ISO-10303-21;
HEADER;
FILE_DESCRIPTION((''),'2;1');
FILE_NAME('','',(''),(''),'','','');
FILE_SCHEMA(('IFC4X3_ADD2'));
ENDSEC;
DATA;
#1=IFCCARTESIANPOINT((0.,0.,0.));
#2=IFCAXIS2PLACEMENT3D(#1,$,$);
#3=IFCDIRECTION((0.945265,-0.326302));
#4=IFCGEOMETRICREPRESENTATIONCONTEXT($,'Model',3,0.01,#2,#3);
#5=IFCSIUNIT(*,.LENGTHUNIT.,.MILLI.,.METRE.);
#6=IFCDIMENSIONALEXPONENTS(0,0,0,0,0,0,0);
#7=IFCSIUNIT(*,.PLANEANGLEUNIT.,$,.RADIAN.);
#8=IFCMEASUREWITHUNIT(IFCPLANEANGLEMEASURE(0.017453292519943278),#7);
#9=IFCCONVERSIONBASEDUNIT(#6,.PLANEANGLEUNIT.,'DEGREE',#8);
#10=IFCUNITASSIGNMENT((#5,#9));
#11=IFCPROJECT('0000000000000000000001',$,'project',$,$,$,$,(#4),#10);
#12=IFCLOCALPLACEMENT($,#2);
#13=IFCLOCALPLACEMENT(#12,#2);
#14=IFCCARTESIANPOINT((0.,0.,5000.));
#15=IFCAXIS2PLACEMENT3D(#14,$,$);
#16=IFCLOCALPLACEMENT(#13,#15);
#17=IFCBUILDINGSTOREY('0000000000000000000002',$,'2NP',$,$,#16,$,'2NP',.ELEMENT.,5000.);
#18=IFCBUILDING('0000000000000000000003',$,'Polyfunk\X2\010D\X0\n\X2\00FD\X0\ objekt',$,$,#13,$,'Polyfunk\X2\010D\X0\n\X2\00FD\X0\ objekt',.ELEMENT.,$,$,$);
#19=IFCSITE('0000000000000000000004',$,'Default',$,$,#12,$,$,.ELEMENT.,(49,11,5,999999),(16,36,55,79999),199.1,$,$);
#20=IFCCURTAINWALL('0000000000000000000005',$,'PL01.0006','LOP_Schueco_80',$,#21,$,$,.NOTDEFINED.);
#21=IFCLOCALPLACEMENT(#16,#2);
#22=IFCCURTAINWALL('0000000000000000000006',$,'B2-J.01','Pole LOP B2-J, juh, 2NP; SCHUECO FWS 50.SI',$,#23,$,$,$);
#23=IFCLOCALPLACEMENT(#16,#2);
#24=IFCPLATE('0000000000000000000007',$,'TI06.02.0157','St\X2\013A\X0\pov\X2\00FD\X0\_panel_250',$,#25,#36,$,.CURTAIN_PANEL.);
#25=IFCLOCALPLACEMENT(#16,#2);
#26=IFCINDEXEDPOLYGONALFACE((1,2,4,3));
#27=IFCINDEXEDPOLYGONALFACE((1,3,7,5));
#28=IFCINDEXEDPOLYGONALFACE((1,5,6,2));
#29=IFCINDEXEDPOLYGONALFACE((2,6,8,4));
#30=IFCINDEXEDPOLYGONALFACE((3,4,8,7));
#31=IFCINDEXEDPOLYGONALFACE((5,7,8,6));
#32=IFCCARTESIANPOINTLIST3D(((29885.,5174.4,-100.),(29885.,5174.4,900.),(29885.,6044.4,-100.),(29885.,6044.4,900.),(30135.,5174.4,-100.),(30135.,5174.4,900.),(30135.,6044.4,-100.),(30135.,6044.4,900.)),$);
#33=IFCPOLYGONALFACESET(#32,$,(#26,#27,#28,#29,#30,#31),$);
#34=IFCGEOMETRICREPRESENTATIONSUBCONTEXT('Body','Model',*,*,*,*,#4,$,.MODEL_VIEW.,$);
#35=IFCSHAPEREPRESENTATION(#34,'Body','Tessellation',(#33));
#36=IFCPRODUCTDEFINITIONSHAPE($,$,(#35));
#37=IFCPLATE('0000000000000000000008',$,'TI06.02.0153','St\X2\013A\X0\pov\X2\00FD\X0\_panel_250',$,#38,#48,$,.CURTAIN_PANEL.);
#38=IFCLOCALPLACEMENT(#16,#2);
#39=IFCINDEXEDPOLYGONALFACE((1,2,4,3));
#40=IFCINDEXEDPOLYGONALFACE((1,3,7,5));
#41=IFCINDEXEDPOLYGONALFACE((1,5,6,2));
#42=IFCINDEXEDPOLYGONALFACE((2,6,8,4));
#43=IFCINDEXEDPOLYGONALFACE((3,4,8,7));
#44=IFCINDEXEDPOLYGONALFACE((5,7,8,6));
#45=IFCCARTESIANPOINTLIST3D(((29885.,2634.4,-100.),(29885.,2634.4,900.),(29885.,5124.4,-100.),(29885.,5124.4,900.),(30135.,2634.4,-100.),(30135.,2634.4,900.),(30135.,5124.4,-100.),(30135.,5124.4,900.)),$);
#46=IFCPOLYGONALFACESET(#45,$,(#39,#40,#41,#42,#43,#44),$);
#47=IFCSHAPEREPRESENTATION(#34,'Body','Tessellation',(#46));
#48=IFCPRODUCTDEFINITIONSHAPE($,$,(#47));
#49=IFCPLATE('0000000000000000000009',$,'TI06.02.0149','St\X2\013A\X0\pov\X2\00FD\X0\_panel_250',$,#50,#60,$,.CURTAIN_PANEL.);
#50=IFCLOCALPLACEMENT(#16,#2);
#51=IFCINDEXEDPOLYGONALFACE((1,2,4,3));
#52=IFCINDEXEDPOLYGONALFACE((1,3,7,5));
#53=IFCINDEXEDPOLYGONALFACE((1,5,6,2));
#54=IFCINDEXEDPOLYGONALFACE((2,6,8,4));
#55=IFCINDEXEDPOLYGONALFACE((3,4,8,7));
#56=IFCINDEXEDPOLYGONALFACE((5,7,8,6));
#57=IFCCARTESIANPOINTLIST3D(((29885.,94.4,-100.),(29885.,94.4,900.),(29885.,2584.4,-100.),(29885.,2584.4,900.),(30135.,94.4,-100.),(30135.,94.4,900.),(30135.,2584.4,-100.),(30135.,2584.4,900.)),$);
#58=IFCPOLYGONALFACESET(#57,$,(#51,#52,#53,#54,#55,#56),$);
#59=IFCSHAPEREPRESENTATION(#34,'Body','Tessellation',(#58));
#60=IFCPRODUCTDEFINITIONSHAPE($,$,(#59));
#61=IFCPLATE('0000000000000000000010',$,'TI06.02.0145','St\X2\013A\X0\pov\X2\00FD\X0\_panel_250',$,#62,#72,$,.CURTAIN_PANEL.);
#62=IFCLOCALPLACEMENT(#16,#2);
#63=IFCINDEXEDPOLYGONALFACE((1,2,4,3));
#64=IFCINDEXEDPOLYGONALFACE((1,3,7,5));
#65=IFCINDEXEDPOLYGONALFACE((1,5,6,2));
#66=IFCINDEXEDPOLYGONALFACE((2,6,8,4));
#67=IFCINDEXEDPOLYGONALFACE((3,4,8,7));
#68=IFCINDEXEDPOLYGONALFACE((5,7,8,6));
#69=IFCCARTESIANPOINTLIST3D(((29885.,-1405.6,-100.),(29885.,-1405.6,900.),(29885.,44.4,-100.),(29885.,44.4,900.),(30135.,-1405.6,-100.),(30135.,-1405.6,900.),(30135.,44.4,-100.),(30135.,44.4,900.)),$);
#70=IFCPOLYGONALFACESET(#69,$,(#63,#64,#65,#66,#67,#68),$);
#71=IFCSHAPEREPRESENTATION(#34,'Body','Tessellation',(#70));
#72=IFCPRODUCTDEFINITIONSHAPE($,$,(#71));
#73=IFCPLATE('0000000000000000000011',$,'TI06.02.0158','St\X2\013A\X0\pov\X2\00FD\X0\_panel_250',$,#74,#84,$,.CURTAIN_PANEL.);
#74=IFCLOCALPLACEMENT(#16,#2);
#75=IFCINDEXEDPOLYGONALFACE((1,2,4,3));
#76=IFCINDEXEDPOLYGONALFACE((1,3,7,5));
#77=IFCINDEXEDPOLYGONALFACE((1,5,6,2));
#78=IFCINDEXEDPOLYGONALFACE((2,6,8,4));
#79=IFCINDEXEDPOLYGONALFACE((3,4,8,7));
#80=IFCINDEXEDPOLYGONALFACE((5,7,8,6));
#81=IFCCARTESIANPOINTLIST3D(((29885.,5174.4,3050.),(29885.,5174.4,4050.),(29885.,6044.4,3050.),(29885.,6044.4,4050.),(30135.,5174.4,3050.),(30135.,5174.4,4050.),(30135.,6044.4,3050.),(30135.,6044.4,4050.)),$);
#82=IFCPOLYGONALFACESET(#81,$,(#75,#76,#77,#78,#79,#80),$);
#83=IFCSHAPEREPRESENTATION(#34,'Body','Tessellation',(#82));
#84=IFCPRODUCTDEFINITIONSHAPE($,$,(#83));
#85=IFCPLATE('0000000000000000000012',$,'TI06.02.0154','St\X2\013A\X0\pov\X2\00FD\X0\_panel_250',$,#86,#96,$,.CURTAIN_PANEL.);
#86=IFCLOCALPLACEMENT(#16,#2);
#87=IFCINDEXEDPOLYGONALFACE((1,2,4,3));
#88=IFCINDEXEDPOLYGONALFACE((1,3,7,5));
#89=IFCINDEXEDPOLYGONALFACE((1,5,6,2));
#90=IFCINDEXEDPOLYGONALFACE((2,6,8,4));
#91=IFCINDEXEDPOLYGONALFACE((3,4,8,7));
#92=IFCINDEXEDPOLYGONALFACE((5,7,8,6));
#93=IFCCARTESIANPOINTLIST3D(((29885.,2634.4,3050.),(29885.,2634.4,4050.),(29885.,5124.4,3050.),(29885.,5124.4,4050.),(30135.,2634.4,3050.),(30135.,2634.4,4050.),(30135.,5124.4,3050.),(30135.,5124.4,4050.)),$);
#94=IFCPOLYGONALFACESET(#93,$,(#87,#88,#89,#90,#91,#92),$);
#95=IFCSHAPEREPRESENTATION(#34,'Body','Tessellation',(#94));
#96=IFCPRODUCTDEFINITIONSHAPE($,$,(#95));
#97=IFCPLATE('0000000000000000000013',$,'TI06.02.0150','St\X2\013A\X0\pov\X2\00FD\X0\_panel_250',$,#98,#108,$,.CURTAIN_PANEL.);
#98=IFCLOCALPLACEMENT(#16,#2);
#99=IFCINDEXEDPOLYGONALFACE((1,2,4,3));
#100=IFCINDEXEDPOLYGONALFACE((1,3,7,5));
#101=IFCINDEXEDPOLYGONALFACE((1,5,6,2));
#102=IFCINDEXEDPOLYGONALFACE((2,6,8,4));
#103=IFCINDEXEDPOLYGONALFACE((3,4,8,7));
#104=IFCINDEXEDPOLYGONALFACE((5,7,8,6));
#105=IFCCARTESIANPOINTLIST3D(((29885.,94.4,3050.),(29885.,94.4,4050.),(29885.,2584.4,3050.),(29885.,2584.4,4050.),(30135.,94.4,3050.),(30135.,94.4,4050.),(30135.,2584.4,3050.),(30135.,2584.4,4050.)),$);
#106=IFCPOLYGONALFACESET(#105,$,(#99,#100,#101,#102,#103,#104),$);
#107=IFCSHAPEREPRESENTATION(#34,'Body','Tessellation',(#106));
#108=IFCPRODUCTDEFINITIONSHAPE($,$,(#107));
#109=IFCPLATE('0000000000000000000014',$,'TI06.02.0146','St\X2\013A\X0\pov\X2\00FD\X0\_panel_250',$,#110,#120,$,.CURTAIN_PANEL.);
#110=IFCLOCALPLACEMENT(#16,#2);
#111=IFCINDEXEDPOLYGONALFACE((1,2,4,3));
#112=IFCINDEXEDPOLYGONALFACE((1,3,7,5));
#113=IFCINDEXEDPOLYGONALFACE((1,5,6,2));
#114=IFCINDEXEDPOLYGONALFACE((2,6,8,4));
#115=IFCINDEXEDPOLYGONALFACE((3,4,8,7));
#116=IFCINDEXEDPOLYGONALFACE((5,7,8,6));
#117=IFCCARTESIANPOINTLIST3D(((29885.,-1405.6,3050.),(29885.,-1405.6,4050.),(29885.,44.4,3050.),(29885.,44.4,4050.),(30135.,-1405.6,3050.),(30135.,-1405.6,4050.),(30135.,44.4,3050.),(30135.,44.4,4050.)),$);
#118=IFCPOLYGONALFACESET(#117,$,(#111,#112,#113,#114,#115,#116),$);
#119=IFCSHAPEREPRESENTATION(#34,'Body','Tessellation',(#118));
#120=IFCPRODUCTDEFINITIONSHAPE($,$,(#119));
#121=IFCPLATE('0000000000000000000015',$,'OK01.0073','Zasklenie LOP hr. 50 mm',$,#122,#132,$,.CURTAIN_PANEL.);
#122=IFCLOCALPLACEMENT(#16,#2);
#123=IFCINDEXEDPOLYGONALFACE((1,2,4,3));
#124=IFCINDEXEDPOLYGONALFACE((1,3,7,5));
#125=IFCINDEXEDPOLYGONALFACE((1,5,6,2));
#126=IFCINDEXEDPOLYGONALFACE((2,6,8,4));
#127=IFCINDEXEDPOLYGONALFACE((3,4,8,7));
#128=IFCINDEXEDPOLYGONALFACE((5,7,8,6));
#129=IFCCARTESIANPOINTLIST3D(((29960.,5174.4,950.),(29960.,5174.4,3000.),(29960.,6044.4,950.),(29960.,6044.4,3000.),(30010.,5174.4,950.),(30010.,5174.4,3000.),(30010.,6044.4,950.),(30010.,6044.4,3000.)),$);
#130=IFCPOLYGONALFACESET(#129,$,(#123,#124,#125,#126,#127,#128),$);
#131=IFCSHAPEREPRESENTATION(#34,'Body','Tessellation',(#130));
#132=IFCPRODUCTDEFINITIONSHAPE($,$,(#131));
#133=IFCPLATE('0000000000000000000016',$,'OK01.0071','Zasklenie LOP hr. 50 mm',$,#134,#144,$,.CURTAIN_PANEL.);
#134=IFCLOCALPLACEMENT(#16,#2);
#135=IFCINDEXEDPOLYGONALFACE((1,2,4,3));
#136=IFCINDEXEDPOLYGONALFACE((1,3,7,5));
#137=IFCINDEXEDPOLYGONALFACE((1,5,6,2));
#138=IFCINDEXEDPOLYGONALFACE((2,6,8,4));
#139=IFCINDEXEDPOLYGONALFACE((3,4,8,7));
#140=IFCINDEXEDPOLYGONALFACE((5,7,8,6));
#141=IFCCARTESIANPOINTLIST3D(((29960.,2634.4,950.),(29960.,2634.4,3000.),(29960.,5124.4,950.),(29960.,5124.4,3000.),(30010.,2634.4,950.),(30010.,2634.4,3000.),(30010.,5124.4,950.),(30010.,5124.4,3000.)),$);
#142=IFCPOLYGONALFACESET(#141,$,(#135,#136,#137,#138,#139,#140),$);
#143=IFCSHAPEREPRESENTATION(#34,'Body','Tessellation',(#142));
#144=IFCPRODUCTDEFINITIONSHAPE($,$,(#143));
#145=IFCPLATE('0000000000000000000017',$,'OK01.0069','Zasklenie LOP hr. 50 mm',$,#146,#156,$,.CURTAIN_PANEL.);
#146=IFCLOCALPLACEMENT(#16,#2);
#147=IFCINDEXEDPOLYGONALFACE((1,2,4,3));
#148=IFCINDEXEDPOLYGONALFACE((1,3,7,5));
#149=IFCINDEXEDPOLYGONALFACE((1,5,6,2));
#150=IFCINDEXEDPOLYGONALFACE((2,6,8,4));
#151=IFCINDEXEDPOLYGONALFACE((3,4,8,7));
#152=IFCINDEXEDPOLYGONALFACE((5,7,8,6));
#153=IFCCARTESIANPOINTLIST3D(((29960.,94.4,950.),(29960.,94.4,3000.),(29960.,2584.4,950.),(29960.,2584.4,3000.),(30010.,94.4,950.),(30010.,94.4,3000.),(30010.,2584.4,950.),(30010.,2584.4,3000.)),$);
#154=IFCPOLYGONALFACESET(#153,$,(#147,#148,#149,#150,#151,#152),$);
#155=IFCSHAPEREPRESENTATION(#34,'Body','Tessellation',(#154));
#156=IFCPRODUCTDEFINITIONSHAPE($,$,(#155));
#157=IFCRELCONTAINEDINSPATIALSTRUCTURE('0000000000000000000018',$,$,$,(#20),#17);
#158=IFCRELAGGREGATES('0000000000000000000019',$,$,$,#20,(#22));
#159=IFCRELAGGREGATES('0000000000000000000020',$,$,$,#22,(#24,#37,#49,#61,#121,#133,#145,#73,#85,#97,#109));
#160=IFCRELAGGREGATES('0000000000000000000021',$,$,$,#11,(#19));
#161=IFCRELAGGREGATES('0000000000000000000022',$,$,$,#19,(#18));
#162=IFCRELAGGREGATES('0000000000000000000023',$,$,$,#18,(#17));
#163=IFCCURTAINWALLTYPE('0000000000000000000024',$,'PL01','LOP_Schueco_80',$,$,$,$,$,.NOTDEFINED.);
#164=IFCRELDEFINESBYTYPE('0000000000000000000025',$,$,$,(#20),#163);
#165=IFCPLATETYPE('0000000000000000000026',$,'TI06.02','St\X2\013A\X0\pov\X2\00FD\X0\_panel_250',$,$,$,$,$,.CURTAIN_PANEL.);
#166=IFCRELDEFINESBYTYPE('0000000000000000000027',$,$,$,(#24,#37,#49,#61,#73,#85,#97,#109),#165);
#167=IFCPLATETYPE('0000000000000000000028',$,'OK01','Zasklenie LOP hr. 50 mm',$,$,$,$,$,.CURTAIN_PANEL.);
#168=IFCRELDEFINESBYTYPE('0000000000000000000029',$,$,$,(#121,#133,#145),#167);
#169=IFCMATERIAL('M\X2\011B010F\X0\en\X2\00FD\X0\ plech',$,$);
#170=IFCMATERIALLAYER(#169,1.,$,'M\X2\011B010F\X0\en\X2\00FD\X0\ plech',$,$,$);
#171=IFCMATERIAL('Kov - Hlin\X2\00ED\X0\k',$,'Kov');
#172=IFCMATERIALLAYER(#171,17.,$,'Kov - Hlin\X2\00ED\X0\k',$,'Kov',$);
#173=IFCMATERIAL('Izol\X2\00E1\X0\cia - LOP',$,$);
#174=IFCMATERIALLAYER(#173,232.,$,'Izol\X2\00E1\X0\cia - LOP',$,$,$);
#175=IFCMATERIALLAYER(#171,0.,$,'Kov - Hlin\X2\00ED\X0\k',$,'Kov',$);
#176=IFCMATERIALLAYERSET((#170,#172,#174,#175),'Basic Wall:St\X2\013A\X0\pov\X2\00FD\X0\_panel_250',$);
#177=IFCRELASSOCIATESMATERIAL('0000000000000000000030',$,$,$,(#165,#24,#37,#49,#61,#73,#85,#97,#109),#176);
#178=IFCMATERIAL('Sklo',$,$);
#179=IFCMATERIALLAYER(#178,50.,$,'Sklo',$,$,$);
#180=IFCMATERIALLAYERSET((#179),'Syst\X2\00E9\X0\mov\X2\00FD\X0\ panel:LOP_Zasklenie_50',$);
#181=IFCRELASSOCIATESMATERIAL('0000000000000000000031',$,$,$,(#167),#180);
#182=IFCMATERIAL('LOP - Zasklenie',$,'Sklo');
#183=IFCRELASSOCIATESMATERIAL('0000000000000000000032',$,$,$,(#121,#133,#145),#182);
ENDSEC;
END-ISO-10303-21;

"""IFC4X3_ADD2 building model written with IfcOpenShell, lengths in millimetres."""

from ifc_helpers import new_model, entity, si_unit, converted_unit, direction, frame, frame_2d, origin, origin_2d_with_axis, place, context, subcontext, project, spatial, rectangle, extrude, source, transform, mapped, material, layer, layer_set, layer_usage, type_object, type_shapes, element, aggregate, save


model = new_model("IFC4X3_ADD2")

# Units and contexts
model_context = context("Model", 3, precision=0.01, world=origin(), true_north=direction((0.945265, -0.326302)))
body_context = subcontext(model_context, "Body", "Model", "MODEL_VIEW")
ifc_project = project(units=[si_unit("LENGTHUNIT", "METRE", prefix="MILLI"), converted_unit("PLANEANGLEUNIT", "DEGREE", entity("IfcPlaneAngleMeasure", 0.017453292519943278), si_unit("PLANEANGLEUNIT", "RADIAN"), dimensions=[0, 0, 0, 0, 0, 0, 0])], contexts=[model_context])

# Site, building, storey
site_placement = place(None, origin())
site = spatial("IfcSite", under=ifc_project, at=site_placement, Name="Default", CompositionType="ELEMENT", RefLatitude=(49, 11, 5, 999999), RefLongitude=(16, 36, 55, 79999), RefElevation=199.1)
building_placement = place(site_placement, origin())
building = spatial("IfcBuilding", under=site, at=building_placement, Name="Polyfunkčný objekt", LongName="Polyfunkčný objekt", CompositionType="ELEMENT")
storey_placement = place(building_placement, frame((0.0, 0.0, 5000.0)))
storey = spatial("IfcBuildingStorey", under=building, at=storey_placement, Name="2NP", LongName="2NP", CompositionType="ELEMENT", Elevation=5000.0)

# Shared definitions
curtain_wall_type = type_object("IfcCurtainWallType", Name="PL01", Description="LOP_Schueco_80", PredefinedType="NOTDEFINED")

# Curtain walls
curtain_wall_1_placement = place(storey_placement, frame((0.0, 0.0, -5000.0)))
curtain_wall_1 = element("IfcCurtainWall", 1, at=curtain_wall_1_placement, inside=storey, type_object=curtain_wall_type, Name="PL01.0006", Description="LOP_Schueco_80", PredefinedType="NOTDEFINED")
curtain_wall_2 = element("IfcCurtainWall", 2, Name="B2-J.01", Description="Pole LOP B2-J, juh, 2NP; SCHUECO FWS 50.SI")
aggregate(curtain_wall_1, [curtain_wall_2])

# Plates
ifc_material_1 = material(Name="Měďený plech")
ifc_layer_1 = layer(ifc_material_1, 1.0, Name="Měďený plech")
ifc_material_2 = material(Name="Kov - Hliník", Category="Kov")
ifc_layer_2 = layer(ifc_material_2, 17.0, Name="Kov - Hliník", Category="Kov")
ifc_material_3 = material(Name="Izolácia - LOP")
ifc_layer_3 = layer(ifc_material_3, 232.0, Name="Izolácia - LOP")
ifc_layer_4 = layer(ifc_material_2, 0.0, Name="Kov - Hliník", Category="Kov")
ifc_layer_set_1 = layer_set([ifc_layer_1, ifc_layer_2, ifc_layer_3, ifc_layer_4], Name="Basic Wall:Stĺpový_panel_250")
ifc_layer_usage_1 = layer_usage(ifc_layer_set_1, "AXIS2", "POSITIVE", -125.0)
plate_type_1 = type_object("IfcPlateType", Name="TI06.02", Description="Stĺpový_panel_250", PredefinedType="CURTAIN_PANEL", material=ifc_layer_set_1)
plate_1_placement = place(storey_placement, frame((30010.0, 6044.4, -100.0), z_axis=(0.0, 0.0, 1.0), x_axis=(0.0, -1.0, 0.0)))
plate_1 = element("IfcPlate", 3, at=plate_1_placement, type_object=plate_type_1, material=ifc_layer_usage_1, Name="TI06.02.0157", Description="Stĺpový_panel_250", PredefinedType="CURTAIN_PANEL", context=body_context, shape_type="SweptSolid", body=[
    extrude(rectangle(XDim=250.0, YDim=870.0, at=frame_2d((0.0, 0.0), x_axis=(1.0, 0.0))), frame((435.0, 0.0, 0.0), z_axis=(0.0, 0.0, 1.0), x_axis=(0.0, 1.0, 0.0)), (0.0, 0.0, 1.0), 1000.0),
])
ifc_layer_usage_2 = layer_usage(ifc_layer_set_1, "AXIS2", "POSITIVE", -125.0)
plate_2_placement = place(storey_placement, frame((30010.0, 5124.4, -100.0), z_axis=(0.0, 0.0, 1.0), x_axis=(0.0, -1.0, 0.0)))
plate_2 = element("IfcPlate", 4, at=plate_2_placement, type_object=plate_type_1, material=ifc_layer_usage_2, Name="TI06.02.0153", Description="Stĺpový_panel_250", PredefinedType="CURTAIN_PANEL", context=body_context, shape_type="SweptSolid", body=[
    extrude(rectangle(XDim=250.0, YDim=2490.0, at=frame_2d((0.0, 0.0), x_axis=(1.0, 0.0))), frame((1245.0, 0.0, 0.0), z_axis=(0.0, 0.0, 1.0), x_axis=(0.0, 1.0, 0.0)), (0.0, 0.0, 1.0), 1000.0),
])
ifc_layer_usage_3 = layer_usage(ifc_layer_set_1, "AXIS2", "POSITIVE", -125.0)
plate_3_placement = place(storey_placement, frame((30010.0, 2584.4, -100.0), z_axis=(0.0, 0.0, 1.0), x_axis=(0.0, -1.0, 0.0)))
plate_3 = element("IfcPlate", 5, at=plate_3_placement, type_object=plate_type_1, material=ifc_layer_usage_3, Name="TI06.02.0149", Description="Stĺpový_panel_250", PredefinedType="CURTAIN_PANEL", context=body_context, shape_type="SweptSolid", body=[
    extrude(rectangle(XDim=250.0, YDim=2490.0, at=frame_2d((0.0, 0.0), x_axis=(1.0, 0.0))), frame((1245.0, 0.0, 0.0), z_axis=(0.0, 0.0, 1.0), x_axis=(0.0, 1.0, 0.0)), (0.0, 0.0, 1.0), 1000.0),
])
ifc_layer_usage_4 = layer_usage(ifc_layer_set_1, "AXIS2", "POSITIVE", -125.0)
plate_4_placement = place(storey_placement, frame((30010.0, 44.4, -100.0), z_axis=(0.0, 0.0, 1.0), x_axis=(0.0, -1.0, 0.0)))
plate_4 = element("IfcPlate", 6, at=plate_4_placement, type_object=plate_type_1, material=ifc_layer_usage_4, Name="TI06.02.0145", Description="Stĺpový_panel_250", PredefinedType="CURTAIN_PANEL", context=body_context, shape_type="SweptSolid", body=[
    extrude(rectangle(XDim=250.0, YDim=1450.0, at=frame_2d((0.0, 0.0), x_axis=(1.0, 0.0))), frame((725.0, 0.0, 0.0), z_axis=(0.0, 0.0, 1.0), x_axis=(0.0, 1.0, 0.0)), (0.0, 0.0, 1.0), 1000.0),
])
ifc_layer_usage_5 = layer_usage(ifc_layer_set_1, "AXIS2", "POSITIVE", -125.0)
plate_5_placement = place(storey_placement, frame((30010.0, 6044.4, 3050.0), z_axis=(0.0, 0.0, 1.0), x_axis=(0.0, -1.0, 0.0)))
plate_5 = element("IfcPlate", 7, at=plate_5_placement, type_object=plate_type_1, material=ifc_layer_usage_5, Name="TI06.02.0158", Description="Stĺpový_panel_250", PredefinedType="CURTAIN_PANEL", context=body_context, shape_type="SweptSolid", body=[
    extrude(rectangle(XDim=250.0, YDim=870.0, at=frame_2d((0.0, 0.0), x_axis=(1.0, 0.0))), frame((435.0, 0.0, 0.0), z_axis=(0.0, 0.0, 1.0), x_axis=(0.0, 1.0, 0.0)), (0.0, 0.0, 1.0), 1000.0),
])
ifc_layer_usage_6 = layer_usage(ifc_layer_set_1, "AXIS2", "POSITIVE", -125.0)
plate_6_placement = place(storey_placement, frame((30010.0, 5124.4, 3050.0), z_axis=(0.0, 0.0, 1.0), x_axis=(0.0, -1.0, 0.0)))
plate_6 = element("IfcPlate", 8, at=plate_6_placement, type_object=plate_type_1, material=ifc_layer_usage_6, Name="TI06.02.0154", Description="Stĺpový_panel_250", PredefinedType="CURTAIN_PANEL", context=body_context, shape_type="SweptSolid", body=[
    extrude(rectangle(XDim=250.0, YDim=2490.0, at=frame_2d((0.0, 0.0), x_axis=(1.0, 0.0))), frame((1245.0, 0.0, 0.0), z_axis=(0.0, 0.0, 1.0), x_axis=(0.0, 1.0, 0.0)), (0.0, 0.0, 1.0), 1000.0),
])
ifc_layer_usage_7 = layer_usage(ifc_layer_set_1, "AXIS2", "POSITIVE", -125.0)
plate_7_placement = place(storey_placement, frame((30010.0, 2584.4, 3050.0), z_axis=(0.0, 0.0, 1.0), x_axis=(0.0, -1.0, 0.0)))
plate_7 = element("IfcPlate", 9, at=plate_7_placement, type_object=plate_type_1, material=ifc_layer_usage_7, Name="TI06.02.0150", Description="Stĺpový_panel_250", PredefinedType="CURTAIN_PANEL", context=body_context, shape_type="SweptSolid", body=[
    extrude(rectangle(XDim=250.0, YDim=2490.0, at=frame_2d((0.0, 0.0), x_axis=(1.0, 0.0))), frame((1245.0, 0.0, 0.0), z_axis=(0.0, 0.0, 1.0), x_axis=(0.0, 1.0, 0.0)), (0.0, 0.0, 1.0), 1000.0),
])
ifc_layer_usage_8 = layer_usage(ifc_layer_set_1, "AXIS2", "POSITIVE", -125.0)
plate_8_placement = place(storey_placement, frame((30010.0, 44.4, 3050.0), z_axis=(0.0, 0.0, 1.0), x_axis=(0.0, -1.0, 0.0)))
plate_8 = element("IfcPlate", 10, at=plate_8_placement, type_object=plate_type_1, material=ifc_layer_usage_8, Name="TI06.02.0146", Description="Stĺpový_panel_250", PredefinedType="CURTAIN_PANEL", context=body_context, shape_type="SweptSolid", body=[
    extrude(rectangle(XDim=250.0, YDim=1450.0, at=frame_2d((0.0, 0.0), x_axis=(1.0, 0.0))), frame((725.0, 0.0, 0.0), z_axis=(0.0, 0.0, 1.0), x_axis=(0.0, 1.0, 0.0)), (0.0, 0.0, 1.0), 1000.0),
])
ifc_material_4 = material(Name="LOP - Zasklenie", Category="Sklo")
ifc_material_5 = material(Name="Sklo")
ifc_layer_5 = layer(ifc_material_5, 50.0, Name="Sklo")
ifc_layer_set_2 = layer_set([ifc_layer_5], Name="Systémový panel:LOP_Zasklenie_50")
plate_type_2 = type_object("IfcPlateType", Name="OK01", Description="Zasklenie LOP hr. 50 mm", PredefinedType="CURTAIN_PANEL", material=ifc_layer_set_2)
shared_shape_1 = source(origin(), body_context, "Body", "SweptSolid", [
    extrude(rectangle(XDim=50.0, YDim=870.0, at=origin_2d_with_axis()), frame((0.0, -25.0, 0.0), z_axis=(0.0, 0.0, 1.0), x_axis=(0.0, 1.0, 0.0)), (0.0, 0.0, 1.0), 2050.0),
])
plate_9_placement = place(curtain_wall_1_placement, frame((30010.0, 5609.4, 5950.0), z_axis=(0.0, 0.0, 1.0), x_axis=(0.0, -1.0, 0.0)))
plate_9 = element("IfcPlate", 11, at=plate_9_placement, type_object=plate_type_2, material=ifc_material_4, Name="OK01.0073", Description="Zasklenie LOP hr. 50 mm", PredefinedType="CURTAIN_PANEL", context=body_context, shape_type="MappedRepresentation", body=[
    mapped(shared_shape_1, transform((0.0, 0.0, 0.0), scale=1.0)),
])
shared_shape_2 = source(origin(), body_context, "Body", "SweptSolid", [
    extrude(rectangle(XDim=50.0, YDim=2490.0, at=origin_2d_with_axis()), frame((0.0, -25.0, 0.0), z_axis=(0.0, 0.0, 1.0), x_axis=(0.0, 1.0, 0.0)), (0.0, 0.0, 1.0), 2050.0),
])
type_shapes(plate_type_2, [shared_shape_1, shared_shape_2])
plate_10_placement = place(curtain_wall_1_placement, frame((30010.0, 3879.4, 5950.0), z_axis=(0.0, 0.0, 1.0), x_axis=(0.0, -1.0, 0.0)))
plate_10 = element("IfcPlate", 12, at=plate_10_placement, type_object=plate_type_2, material=ifc_material_4, Name="OK01.0071", Description="Zasklenie LOP hr. 50 mm", PredefinedType="CURTAIN_PANEL", context=body_context, shape_type="MappedRepresentation", body=[
    mapped(shared_shape_2, transform((0.0, 0.0, 0.0), scale=1.0)),
])
plate_11_placement = place(curtain_wall_1_placement, frame((30010.0, 1339.4, 5950.0), z_axis=(0.0, 0.0, 1.0), x_axis=(0.0, -1.0, 0.0)))
plate_11 = element("IfcPlate", 13, at=plate_11_placement, type_object=plate_type_2, material=ifc_material_4, Name="OK01.0069", Description="Zasklenie LOP hr. 50 mm", PredefinedType="CURTAIN_PANEL", context=body_context, shape_type="MappedRepresentation", body=[
    mapped(shared_shape_2, transform((0.0, 0.0, 0.0), scale=1.0)),
])
aggregate(curtain_wall_2, [plate_1, plate_2, plate_3, plate_4, plate_9, plate_10, plate_11, plate_5, plate_6, plate_7, plate_8])

save(model, "model.ifc")
